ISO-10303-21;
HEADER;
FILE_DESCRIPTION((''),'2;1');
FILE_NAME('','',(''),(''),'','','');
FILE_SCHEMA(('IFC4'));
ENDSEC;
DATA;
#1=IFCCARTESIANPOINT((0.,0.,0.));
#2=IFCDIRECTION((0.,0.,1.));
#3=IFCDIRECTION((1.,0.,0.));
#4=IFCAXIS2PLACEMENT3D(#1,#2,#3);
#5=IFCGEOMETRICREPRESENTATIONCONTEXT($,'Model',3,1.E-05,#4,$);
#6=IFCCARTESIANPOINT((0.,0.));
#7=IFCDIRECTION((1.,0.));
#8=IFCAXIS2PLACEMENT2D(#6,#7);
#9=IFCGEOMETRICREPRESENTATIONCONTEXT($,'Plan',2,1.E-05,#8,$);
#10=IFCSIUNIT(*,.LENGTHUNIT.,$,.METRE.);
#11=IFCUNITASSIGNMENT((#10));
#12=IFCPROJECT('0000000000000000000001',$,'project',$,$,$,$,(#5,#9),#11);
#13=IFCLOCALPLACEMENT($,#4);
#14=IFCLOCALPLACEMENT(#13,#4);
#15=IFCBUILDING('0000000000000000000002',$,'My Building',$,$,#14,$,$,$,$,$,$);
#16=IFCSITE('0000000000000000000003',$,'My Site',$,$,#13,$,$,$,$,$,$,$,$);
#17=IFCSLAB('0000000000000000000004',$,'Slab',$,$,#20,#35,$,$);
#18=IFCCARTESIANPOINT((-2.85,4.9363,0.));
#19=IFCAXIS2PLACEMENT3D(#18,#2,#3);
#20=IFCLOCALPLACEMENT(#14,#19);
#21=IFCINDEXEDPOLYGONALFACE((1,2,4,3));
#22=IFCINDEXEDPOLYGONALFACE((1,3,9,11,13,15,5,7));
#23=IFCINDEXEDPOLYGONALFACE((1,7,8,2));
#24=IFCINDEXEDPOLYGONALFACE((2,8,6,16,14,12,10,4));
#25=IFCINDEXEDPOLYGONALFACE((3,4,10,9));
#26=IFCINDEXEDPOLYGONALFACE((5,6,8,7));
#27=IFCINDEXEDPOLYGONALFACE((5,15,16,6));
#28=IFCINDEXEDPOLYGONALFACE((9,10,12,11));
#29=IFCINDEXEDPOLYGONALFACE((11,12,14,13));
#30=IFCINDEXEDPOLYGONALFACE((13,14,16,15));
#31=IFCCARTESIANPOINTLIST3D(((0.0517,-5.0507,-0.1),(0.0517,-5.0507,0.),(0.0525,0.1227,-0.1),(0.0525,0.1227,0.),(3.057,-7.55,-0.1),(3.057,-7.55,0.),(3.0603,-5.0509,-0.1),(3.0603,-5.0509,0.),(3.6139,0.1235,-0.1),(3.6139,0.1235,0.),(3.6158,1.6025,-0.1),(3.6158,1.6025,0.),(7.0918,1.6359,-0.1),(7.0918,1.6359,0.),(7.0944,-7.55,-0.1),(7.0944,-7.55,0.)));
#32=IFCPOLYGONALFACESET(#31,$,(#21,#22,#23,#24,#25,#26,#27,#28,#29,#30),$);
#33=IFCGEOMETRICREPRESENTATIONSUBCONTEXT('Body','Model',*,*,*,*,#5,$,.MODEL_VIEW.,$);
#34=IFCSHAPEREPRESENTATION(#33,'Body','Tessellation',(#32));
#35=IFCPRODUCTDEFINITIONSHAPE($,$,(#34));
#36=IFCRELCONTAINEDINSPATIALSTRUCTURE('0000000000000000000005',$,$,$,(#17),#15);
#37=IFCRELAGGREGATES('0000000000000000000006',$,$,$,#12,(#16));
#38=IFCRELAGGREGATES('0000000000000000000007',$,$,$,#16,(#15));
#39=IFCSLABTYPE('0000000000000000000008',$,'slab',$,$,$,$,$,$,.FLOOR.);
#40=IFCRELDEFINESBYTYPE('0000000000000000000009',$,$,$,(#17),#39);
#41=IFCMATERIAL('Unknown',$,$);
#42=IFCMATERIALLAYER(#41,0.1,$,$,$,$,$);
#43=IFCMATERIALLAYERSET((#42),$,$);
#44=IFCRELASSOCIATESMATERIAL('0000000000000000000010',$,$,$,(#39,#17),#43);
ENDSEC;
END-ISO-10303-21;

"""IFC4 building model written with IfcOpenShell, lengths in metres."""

from ifc_helpers import new_model, si_unit, frame, origin_with_axes, origin_2d_with_axis, place, context, subcontext, project, spatial, indexed_curve, outline, extrude, material, layer, layer_set, layer_usage, type_object, element, save


model = new_model("IFC4")

# Units and contexts
model_context = context("Model", 3, precision=1e-05, world=origin_with_axes())
plan_context = context("Plan", 2, precision=1e-05, world=origin_2d_with_axis())
body_context_1 = subcontext(model_context, "Body", "Model", "MODEL_VIEW")
ifc_project = project(units=[si_unit("LENGTHUNIT", "METRE")], contexts=[model_context, plan_context])

# Site, building
site_placement = place(None, origin_with_axes())
site = spatial("IfcSite", under=ifc_project, at=site_placement, Name="My Site")
building_placement = place(site_placement, origin_with_axes())
building = spatial("IfcBuilding", under=site, at=building_placement, Name="My Building")

# Slab
ifc_material = material(Name="Unknown")
ifc_layer_1 = layer(ifc_material, 0.1)
ifc_layer_set_1 = layer_set([ifc_layer_1])
ifc_layer_usage_1 = layer_usage(ifc_layer_set_1, "AXIS3", "POSITIVE", -0.1)
slab_type = type_object("IfcSlabType", Name="slab", PredefinedType="FLOOR", material=ifc_layer_set_1)
slab_placement = place(building_placement, frame((-2.85, 4.9363, 0.0), z_axis=(0.0, 0.0, 1.0), x_axis=(1.0, 0.0, 0.0)))
element("IfcSlab", 1, at=slab_placement, inside=building, type_object=slab_type, material=ifc_layer_usage_1, Name="Slab", context=body_context_1, shape_type="SweptSolid", body=[
    extrude(outline(indexed_curve([(3.6139, 0.1235), (3.6158, 1.6025), (7.0918, 1.6359), (7.0944, -7.55), (3.057, -7.55), (3.0603, -5.0509), (0.0517, -5.0507), (0.0525, 0.1227), (3.6139, 0.1235)])), frame((0.0, 0.0, -0.1), z_axis=(0.0, 0.0, 1.0), x_axis=(1.0, 0.0, 0.0)), (0.0, 0.0, 1.0), 0.1),
])

save(model, "model.ifc")
